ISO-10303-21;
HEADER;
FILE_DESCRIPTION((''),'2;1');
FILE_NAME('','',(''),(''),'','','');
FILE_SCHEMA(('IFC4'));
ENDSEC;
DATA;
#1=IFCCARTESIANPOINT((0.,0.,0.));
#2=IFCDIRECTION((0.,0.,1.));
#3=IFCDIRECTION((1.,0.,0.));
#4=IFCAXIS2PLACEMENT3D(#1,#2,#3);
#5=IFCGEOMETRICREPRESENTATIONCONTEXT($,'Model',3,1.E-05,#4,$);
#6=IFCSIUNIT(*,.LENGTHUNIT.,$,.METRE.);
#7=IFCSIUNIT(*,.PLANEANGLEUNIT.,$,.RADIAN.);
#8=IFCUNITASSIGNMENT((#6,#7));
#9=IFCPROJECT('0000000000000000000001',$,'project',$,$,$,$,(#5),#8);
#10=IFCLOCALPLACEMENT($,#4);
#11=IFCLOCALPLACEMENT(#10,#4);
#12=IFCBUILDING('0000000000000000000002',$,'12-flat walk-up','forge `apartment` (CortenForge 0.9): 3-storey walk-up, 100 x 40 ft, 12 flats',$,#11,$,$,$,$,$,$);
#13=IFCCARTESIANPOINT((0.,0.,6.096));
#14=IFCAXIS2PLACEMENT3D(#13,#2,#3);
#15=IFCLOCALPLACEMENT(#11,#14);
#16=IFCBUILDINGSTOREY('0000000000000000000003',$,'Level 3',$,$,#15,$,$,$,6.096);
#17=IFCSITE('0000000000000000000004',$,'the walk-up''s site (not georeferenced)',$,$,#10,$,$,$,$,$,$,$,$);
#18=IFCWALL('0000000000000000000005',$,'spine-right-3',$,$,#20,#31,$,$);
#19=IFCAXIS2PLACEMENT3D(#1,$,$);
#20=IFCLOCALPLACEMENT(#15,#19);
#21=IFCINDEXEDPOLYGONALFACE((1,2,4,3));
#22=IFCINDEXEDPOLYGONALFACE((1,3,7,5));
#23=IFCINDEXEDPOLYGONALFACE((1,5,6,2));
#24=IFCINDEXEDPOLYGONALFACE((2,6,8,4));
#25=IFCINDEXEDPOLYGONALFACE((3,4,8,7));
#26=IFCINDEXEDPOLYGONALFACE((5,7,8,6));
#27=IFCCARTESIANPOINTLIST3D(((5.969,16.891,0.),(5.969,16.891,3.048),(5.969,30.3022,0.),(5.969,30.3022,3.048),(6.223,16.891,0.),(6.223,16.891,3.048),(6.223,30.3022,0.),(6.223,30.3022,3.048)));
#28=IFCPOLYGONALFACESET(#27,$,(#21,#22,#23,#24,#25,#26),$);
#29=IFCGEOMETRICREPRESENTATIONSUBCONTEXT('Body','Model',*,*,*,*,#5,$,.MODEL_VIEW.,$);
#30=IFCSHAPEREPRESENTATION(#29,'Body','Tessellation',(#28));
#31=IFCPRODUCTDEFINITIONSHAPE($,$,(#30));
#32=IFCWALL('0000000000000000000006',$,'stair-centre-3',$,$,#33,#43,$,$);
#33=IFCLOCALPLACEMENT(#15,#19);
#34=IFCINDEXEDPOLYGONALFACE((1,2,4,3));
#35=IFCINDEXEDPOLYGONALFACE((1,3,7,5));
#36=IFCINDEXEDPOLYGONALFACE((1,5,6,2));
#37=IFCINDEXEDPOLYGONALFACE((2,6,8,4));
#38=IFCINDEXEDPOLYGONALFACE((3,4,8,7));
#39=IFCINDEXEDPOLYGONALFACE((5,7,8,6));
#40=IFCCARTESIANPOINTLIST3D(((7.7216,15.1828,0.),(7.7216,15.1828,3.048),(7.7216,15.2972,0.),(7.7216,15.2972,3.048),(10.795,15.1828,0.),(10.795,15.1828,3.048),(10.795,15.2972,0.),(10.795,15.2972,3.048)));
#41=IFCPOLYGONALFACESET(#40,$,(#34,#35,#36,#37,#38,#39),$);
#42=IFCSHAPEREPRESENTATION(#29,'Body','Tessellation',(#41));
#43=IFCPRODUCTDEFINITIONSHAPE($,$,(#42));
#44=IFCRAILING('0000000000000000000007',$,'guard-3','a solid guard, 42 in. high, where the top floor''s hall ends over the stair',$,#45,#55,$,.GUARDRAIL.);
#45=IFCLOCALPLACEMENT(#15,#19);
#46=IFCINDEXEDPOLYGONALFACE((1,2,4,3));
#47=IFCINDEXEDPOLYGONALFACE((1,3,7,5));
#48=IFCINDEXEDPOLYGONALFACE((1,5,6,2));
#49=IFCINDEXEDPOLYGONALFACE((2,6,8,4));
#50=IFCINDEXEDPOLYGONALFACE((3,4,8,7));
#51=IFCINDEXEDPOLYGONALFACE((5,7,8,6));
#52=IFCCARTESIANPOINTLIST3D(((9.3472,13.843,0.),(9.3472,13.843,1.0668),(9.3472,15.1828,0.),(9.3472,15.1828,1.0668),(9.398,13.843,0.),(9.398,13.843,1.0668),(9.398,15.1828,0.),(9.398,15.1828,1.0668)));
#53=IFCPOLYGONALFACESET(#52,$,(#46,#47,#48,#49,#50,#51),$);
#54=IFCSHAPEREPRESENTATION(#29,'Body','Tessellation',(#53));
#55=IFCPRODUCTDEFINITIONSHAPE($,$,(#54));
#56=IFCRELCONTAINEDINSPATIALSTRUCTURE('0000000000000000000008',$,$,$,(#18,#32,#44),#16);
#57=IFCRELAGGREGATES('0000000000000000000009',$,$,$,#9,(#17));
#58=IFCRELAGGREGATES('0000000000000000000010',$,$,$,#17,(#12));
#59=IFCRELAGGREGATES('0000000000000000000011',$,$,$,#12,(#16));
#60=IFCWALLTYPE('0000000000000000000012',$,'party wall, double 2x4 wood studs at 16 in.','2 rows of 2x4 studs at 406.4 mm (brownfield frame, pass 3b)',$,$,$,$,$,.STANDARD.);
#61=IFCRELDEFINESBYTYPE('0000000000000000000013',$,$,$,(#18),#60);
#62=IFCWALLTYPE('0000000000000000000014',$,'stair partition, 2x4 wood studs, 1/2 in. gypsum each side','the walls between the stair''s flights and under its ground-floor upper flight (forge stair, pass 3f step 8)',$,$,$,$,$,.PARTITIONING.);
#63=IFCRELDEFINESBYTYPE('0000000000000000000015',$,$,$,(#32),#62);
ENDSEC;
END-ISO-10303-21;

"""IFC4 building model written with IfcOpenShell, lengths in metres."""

from ifc_helpers import new_model, si_unit, frame, frame_2d, origin, origin_with_axes, place, context, subcontext, project, spatial, rectangle, extrude, type_object, element, save


model = new_model("IFC4")

# Units and contexts
model_context = context("Model", 3, precision=1e-05, world=origin_with_axes())
body_context = subcontext(model_context, "Body", "Model", "MODEL_VIEW")
ifc_project = project(units=[si_unit("LENGTHUNIT", "METRE"), si_unit("PLANEANGLEUNIT", "RADIAN")], contexts=[model_context])

# Site, building, storey
site_placement = place(None, origin_with_axes())
site = spatial("IfcSite", under=ifc_project, at=site_placement, Name="the walk-up's site (not georeferenced)")
building_placement = place(site_placement, origin_with_axes())
building = spatial("IfcBuilding", under=site, at=building_placement, Name="12-flat walk-up", Description="forge `apartment` (CortenForge 0.9): 3-storey walk-up, 100 x 40 ft, 12 flats")
storey_placement = place(building_placement, frame((0.0, 0.0, 6.096), z_axis=(0.0, 0.0, 1.0), x_axis=(1.0, 0.0, 0.0)))
storey = spatial("IfcBuildingStorey", under=building, at=storey_placement, Name="Level 3", Elevation=6.096)

# Walls
wall_type_1 = type_object("IfcWallType", Name="party wall, double 2x4 wood studs at 16 in.", Description="2 rows of 2x4 studs at 406.4 mm (brownfield frame, pass 3b)", PredefinedType="STANDARD")
wall_1_placement = place(storey_placement, frame((5.969, 16.891, 0.0), z_axis=(0.0, 0.0, 1.0), x_axis=(1.0, 0.0, 0.0)))
element("IfcWall", 1, at=wall_1_placement, inside=storey, type_object=wall_type_1, Name="spine-right-3", context=body_context, shape_type="SweptSolid", body=[
    extrude(rectangle(XDim=0.254, YDim=13.4112, at=frame_2d((0.127, 6.7056))), origin(), (0.0, 0.0, 1.0), 3.048),
])
wall_type_2 = type_object("IfcWallType", Name="stair partition, 2x4 wood studs, 1/2 in. gypsum each side", Description="the walls between the stair's flights and under its ground-floor upper flight (forge stair, pass 3f step 8)", PredefinedType="PARTITIONING")
wall_2_placement = place(storey_placement, frame((7.7216, 15.1829, 0.0), z_axis=(0.0, 0.0, 1.0), x_axis=(1.0, 0.0, 0.0)))
element("IfcWall", 2, at=wall_2_placement, inside=storey, type_object=wall_type_2, Name="stair-centre-3", context=body_context, shape_type="SweptSolid", body=[
    extrude(rectangle(XDim=3.0734, YDim=0.1143, at=frame_2d((1.5367, 0.0572))), origin(), (0.0, 0.0, 1.0), 3.048),
])

# Railing
railing_placement = place(storey_placement, frame((9.3472, 13.843, 0.0), z_axis=(0.0, 0.0, 1.0), x_axis=(1.0, 0.0, 0.0)))
element("IfcRailing", 3, at=railing_placement, inside=storey, Name="guard-3", Description="a solid guard, 42 in. high, where the top floor's hall ends over the stair", PredefinedType="GUARDRAIL", context=body_context, shape_type="SweptSolid", body=[
    extrude(rectangle(XDim=0.0508, YDim=1.3399, at=frame_2d((0.0254, 0.6699))), origin(), (0.0, 0.0, 1.0), 1.0668),
])

save(model, "model.ifc")
